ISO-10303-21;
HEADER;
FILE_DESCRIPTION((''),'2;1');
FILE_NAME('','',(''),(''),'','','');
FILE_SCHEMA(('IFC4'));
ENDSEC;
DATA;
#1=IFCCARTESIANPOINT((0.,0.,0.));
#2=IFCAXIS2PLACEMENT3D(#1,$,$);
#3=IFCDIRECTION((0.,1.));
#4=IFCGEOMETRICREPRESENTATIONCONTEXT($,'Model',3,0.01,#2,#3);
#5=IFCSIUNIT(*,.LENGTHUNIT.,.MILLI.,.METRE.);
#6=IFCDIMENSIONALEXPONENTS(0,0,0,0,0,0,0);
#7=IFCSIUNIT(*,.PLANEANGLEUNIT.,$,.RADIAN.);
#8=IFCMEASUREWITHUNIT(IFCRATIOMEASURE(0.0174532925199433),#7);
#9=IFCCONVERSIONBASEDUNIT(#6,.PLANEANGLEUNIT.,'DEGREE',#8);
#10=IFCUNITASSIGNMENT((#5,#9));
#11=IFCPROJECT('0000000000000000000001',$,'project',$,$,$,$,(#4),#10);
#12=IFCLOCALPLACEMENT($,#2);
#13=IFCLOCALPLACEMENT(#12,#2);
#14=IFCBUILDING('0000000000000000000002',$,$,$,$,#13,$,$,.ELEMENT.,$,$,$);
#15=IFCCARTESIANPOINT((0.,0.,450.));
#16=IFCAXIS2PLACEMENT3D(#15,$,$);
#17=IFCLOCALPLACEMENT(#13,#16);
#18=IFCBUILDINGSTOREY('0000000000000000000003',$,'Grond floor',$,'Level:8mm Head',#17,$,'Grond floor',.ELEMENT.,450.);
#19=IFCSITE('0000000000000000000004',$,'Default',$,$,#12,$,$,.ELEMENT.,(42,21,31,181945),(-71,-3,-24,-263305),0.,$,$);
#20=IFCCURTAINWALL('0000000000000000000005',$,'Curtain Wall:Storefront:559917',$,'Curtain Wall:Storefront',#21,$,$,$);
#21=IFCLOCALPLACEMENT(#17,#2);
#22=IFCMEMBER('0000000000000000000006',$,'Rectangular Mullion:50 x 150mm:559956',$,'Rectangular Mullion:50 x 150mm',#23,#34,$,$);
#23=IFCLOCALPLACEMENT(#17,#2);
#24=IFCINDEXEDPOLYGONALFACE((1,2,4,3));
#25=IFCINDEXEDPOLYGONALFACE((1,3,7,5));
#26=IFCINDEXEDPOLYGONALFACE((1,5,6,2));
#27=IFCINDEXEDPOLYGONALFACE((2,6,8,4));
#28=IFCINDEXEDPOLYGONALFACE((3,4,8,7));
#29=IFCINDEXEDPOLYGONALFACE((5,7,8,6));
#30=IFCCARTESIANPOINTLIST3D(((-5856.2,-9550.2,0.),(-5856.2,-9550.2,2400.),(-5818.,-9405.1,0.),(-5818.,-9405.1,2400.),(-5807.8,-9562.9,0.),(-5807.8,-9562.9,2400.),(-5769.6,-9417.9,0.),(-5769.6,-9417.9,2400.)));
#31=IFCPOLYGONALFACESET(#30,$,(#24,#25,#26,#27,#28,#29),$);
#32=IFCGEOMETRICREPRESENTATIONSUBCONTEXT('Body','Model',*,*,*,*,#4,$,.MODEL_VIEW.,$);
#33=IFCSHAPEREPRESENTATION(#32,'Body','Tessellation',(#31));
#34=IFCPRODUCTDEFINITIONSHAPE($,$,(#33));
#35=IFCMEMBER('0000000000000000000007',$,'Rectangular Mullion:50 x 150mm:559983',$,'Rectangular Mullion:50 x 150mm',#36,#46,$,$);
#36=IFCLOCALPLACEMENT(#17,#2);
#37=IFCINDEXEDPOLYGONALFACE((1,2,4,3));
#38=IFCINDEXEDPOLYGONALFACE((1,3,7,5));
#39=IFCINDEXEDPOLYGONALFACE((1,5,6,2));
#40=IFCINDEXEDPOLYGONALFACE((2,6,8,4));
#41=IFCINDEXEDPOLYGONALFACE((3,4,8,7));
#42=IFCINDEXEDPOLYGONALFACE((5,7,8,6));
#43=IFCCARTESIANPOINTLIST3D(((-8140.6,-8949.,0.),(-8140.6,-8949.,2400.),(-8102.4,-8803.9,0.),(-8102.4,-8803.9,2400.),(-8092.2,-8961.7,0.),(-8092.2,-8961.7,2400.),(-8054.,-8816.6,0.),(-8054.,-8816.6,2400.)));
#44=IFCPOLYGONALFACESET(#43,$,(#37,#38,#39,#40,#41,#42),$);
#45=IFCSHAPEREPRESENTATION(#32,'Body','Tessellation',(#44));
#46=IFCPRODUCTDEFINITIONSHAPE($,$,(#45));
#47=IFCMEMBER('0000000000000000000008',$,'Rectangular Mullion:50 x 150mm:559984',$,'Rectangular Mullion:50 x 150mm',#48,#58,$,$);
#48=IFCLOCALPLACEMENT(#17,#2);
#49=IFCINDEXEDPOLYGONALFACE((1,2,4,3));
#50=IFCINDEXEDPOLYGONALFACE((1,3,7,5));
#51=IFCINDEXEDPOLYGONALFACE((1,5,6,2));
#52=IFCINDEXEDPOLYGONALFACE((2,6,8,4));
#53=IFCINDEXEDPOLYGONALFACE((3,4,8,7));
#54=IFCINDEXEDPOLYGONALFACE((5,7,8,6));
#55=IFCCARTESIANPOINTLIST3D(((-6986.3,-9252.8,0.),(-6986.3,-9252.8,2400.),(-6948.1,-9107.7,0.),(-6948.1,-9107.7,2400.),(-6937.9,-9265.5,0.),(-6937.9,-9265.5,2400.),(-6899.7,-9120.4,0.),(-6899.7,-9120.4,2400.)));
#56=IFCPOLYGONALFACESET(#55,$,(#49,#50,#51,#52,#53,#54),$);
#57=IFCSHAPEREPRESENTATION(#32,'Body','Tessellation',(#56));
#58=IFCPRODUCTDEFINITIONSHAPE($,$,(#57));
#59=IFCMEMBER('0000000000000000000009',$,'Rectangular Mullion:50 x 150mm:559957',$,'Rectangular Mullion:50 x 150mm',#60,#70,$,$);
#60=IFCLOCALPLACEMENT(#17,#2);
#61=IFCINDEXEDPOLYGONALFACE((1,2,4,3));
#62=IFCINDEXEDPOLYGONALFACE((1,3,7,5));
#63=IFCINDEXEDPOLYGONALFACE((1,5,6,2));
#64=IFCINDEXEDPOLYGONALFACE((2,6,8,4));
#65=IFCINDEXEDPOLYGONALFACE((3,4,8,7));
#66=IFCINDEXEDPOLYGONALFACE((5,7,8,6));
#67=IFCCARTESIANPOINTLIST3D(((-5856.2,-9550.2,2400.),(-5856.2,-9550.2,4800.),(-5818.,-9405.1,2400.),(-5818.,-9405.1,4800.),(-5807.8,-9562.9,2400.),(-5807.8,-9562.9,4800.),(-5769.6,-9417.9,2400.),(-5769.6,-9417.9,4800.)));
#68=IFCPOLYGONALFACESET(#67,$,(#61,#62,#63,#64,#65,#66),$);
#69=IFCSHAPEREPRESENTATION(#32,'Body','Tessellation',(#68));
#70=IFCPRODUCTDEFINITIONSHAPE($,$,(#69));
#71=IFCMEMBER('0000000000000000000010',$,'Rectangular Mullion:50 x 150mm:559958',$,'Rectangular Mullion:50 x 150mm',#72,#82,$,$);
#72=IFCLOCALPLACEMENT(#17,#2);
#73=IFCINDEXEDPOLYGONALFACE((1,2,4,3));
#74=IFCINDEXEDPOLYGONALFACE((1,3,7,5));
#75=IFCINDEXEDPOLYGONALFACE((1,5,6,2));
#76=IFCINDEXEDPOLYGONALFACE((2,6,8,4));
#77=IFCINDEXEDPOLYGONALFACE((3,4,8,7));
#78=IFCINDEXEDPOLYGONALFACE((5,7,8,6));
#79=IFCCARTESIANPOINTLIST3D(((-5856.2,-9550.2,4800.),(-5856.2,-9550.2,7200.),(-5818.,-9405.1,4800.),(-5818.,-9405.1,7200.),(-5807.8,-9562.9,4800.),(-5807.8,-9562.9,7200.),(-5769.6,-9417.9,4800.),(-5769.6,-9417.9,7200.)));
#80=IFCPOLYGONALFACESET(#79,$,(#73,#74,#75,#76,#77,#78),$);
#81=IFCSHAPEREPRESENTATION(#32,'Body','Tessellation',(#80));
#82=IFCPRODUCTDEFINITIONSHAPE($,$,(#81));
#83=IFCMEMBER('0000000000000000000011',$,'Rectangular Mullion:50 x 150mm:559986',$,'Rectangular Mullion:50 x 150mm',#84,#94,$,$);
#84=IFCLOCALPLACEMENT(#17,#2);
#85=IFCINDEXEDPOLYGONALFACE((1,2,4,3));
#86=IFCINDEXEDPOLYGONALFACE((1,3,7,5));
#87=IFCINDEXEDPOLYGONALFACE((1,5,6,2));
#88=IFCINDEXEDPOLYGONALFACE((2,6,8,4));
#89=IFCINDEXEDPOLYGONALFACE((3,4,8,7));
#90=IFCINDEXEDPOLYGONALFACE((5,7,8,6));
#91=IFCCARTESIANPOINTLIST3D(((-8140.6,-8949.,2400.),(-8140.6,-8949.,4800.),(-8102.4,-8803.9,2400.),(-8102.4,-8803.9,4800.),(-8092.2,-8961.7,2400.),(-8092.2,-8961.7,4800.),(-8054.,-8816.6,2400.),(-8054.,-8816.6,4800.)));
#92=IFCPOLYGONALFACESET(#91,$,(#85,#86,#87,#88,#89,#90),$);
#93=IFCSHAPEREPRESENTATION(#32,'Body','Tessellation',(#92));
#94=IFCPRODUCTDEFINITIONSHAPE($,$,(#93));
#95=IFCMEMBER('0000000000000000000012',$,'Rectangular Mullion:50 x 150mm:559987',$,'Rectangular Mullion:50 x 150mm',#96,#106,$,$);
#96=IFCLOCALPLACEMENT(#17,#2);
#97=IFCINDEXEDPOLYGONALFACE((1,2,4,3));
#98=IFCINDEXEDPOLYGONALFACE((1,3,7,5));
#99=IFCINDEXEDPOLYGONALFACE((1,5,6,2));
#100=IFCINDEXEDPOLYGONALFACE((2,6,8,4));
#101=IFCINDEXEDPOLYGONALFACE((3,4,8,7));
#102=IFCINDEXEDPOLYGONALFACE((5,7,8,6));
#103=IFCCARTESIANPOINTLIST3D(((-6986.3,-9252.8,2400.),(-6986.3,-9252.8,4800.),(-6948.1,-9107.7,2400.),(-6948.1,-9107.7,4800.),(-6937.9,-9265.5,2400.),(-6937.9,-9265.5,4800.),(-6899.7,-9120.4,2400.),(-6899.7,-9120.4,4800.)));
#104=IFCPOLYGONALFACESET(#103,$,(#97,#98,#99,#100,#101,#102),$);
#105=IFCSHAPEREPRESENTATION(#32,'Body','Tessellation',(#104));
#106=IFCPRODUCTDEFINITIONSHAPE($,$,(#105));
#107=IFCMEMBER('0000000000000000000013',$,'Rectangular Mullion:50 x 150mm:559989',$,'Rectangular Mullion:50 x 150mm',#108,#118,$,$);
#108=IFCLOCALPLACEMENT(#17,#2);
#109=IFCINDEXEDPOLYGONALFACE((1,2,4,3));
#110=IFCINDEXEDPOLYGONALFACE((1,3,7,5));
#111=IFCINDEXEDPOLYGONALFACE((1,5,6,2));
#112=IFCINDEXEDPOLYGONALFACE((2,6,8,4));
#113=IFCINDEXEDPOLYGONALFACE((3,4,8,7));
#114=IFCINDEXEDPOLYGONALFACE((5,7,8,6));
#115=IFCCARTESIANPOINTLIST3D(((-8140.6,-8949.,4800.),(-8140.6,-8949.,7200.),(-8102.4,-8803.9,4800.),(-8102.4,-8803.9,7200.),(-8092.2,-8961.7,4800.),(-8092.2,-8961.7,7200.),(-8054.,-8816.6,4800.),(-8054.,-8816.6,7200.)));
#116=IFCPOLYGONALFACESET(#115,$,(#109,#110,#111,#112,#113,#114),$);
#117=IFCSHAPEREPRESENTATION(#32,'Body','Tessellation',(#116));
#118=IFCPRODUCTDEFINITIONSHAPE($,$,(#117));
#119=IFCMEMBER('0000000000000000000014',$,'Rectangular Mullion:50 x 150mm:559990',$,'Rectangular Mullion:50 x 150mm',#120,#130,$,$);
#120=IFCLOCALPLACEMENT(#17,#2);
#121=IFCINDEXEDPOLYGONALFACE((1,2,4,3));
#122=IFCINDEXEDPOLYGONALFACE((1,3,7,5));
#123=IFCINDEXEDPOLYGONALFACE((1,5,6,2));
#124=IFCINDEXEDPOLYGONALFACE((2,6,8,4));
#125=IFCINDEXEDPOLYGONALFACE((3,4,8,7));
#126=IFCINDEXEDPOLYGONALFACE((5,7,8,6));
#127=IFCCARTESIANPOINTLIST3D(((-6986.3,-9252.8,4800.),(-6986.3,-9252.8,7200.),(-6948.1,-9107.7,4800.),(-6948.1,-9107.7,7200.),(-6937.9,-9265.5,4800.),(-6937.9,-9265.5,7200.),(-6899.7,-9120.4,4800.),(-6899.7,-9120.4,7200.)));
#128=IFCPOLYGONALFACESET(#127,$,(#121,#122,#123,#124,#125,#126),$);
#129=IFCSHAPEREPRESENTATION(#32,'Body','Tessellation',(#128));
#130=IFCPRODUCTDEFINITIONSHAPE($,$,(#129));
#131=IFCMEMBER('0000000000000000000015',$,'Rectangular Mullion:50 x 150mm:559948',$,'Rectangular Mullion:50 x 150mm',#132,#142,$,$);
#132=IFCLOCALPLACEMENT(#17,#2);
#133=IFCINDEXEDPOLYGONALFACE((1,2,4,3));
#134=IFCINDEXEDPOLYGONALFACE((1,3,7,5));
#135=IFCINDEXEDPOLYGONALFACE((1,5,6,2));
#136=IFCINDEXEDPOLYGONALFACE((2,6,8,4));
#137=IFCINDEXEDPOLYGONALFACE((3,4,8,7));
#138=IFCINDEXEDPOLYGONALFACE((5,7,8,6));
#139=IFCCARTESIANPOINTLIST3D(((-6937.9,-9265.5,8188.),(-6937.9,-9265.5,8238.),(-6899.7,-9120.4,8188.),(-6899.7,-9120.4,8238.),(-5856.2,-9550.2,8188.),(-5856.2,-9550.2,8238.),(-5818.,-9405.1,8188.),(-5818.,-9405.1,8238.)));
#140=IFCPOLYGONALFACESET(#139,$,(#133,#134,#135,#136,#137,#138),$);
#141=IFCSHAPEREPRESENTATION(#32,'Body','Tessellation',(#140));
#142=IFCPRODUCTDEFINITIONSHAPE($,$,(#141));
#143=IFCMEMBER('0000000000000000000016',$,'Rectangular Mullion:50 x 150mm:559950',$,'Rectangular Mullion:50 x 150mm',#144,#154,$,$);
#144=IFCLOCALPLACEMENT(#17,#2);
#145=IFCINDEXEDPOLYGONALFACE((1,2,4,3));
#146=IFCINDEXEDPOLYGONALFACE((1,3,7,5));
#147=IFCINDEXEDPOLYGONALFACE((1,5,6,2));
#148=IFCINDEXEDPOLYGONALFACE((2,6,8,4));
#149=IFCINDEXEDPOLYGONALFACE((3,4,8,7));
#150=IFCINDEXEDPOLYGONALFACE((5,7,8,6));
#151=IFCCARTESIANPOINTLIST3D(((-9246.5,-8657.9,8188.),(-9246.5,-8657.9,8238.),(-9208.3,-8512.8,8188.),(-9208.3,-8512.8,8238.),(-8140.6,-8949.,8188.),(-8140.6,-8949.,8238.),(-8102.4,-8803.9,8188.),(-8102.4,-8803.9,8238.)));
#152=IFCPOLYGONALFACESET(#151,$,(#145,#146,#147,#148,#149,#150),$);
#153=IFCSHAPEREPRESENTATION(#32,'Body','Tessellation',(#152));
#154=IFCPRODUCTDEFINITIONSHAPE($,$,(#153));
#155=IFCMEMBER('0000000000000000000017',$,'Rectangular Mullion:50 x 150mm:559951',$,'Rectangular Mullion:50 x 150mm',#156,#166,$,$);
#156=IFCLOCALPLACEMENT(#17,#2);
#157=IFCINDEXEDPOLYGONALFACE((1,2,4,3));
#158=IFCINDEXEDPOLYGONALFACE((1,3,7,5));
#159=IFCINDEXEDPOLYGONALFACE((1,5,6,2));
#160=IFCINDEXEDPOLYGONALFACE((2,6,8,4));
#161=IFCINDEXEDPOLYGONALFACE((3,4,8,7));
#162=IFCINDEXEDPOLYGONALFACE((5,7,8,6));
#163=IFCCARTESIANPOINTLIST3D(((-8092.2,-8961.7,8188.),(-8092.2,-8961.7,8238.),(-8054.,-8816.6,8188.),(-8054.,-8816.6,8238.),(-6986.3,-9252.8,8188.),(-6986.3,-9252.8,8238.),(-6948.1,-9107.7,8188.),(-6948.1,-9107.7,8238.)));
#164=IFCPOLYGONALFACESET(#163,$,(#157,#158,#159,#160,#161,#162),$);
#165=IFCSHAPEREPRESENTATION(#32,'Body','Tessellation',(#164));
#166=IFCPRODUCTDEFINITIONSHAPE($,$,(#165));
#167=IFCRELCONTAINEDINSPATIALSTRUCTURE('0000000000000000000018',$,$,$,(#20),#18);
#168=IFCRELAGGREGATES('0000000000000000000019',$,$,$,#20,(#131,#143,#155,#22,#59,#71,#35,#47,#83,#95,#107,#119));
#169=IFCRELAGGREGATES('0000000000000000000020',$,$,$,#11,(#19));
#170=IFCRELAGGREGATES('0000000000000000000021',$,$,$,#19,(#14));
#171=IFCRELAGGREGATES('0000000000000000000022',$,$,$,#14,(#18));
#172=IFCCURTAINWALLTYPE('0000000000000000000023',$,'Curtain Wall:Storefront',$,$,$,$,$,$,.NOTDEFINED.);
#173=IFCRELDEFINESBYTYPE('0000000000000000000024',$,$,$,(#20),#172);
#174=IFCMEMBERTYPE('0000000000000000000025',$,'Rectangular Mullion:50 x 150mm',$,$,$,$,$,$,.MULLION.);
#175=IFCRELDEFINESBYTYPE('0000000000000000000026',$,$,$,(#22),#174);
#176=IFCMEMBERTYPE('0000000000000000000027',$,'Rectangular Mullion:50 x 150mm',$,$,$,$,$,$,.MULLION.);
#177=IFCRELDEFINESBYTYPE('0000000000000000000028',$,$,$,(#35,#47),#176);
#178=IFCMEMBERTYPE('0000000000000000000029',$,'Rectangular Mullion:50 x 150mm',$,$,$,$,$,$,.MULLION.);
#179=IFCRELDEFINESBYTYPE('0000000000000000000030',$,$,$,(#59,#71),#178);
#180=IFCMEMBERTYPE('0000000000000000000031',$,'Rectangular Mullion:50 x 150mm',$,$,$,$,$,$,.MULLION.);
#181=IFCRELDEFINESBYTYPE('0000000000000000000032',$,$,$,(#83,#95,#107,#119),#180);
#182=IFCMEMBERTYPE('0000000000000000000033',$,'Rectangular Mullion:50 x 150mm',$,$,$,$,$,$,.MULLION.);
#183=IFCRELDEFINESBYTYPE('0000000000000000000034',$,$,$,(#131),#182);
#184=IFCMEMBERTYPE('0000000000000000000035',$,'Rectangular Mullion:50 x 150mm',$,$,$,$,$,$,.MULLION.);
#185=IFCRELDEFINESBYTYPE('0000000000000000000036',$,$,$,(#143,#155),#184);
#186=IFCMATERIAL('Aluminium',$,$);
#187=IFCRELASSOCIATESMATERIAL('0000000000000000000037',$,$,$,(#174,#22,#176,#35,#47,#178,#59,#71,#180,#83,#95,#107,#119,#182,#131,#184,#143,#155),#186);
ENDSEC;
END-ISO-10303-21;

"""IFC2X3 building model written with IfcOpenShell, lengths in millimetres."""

from ifc_helpers import new_model, entity, si_unit, converted_unit, direction, frame, frame_2d, origin, origin_2d_with_axis, place, context, subcontext, project, spatial, rectangle, extrude, source, transform, mapped, material, type_object, type_shapes, element, aggregate, save


model = new_model("IFC2X3")

# Units and contexts
model_context = context("Model", 3, precision=0.01, world=origin(), true_north=direction((0.0, 1.0)))
body_context = subcontext(model_context, "Body", "Model", "MODEL_VIEW")
ifc_project = project(units=[si_unit("LENGTHUNIT", "METRE", prefix="MILLI"), converted_unit("PLANEANGLEUNIT", "DEGREE", entity("IfcRatioMeasure", 0.0174532925199433), si_unit("PLANEANGLEUNIT", "RADIAN"), dimensions=[0, 0, 0, 0, 0, 0, 0])], contexts=[model_context])

# Site, building, storey
site_placement = place(None, origin())
site = spatial("IfcSite", under=ifc_project, at=site_placement, Name="Default", CompositionType="ELEMENT", RefLatitude=(42, 21, 31, 181945), RefLongitude=(-71, -3, -24, -263305), RefElevation=0.0)
building_placement = place(site_placement, origin())
building = spatial("IfcBuilding", under=site, at=building_placement, CompositionType="ELEMENT")
storey_placement = place(building_placement, frame((0.0, 0.0, 450.0)))
storey = spatial("IfcBuildingStorey", under=building, at=storey_placement, Name="Grond floor", ObjectType="Level:8mm Head", LongName="Grond floor", CompositionType="ELEMENT", Elevation=450.0)

# Curtain wall, members
curtain_wall_type = type_object("IfcCurtainWallType", Name="Curtain Wall:Storefront", PredefinedType="NOTDEFINED")
curtain_wall_placement = place(storey_placement, frame((0.0, 0.0, -450.0)))
curtain_wall = element("IfcCurtainWall", 1, at=curtain_wall_placement, inside=storey, type_object=curtain_wall_type, Name="Curtain Wall:Storefront:559917", ObjectType="Curtain Wall:Storefront")
ifc_material_1 = material(Name="Aluminium")
member_type_1 = type_object("IfcMemberType", Name="Rectangular Mullion:50 x 150mm", PredefinedType="MULLION", material=ifc_material_1)
shared_shape_1 = source(origin(), body_context, "Body", "SweptSolid", [
    extrude(rectangle(XDim=150.0, YDim=50.0, at=origin_2d_with_axis()), frame((-25.0, 0.0, -2400.0), z_axis=(0.0, 0.0, 1.0), x_axis=(0.0, -1.0, 0.0)), (0.0, 0.0, 1.0), 2400.0),
])
type_shapes(member_type_1, [shared_shape_1])
member_1_placement = place(storey_placement, frame((-5788.7, -9490.4, 0.0), z_axis=(0.0, 0.0, -1.0), x_axis=(0.967067, -0.25452, 0.0)))
member_1 = element("IfcMember", 2, at=member_1_placement, type_object=member_type_1, material=ifc_material_1, Name="Rectangular Mullion:50 x 150mm:559956", ObjectType="Rectangular Mullion:50 x 150mm", context=body_context, shape_type="MappedRepresentation", body=[
    mapped(shared_shape_1, transform((0.0, 0.0, 0.0), scale=1.0)),
])
member_type_2 = type_object("IfcMemberType", Name="Rectangular Mullion:50 x 150mm", PredefinedType="MULLION", material=ifc_material_1)
shared_shape_2 = source(origin(), body_context, "Body", "SweptSolid", [
    extrude(rectangle(XDim=150.0, YDim=50.0, at=origin_2d_with_axis()), frame((0.0, 0.0, -2400.0), z_axis=(0.0, 0.0, 1.0), x_axis=(0.0, -1.0, 0.0)), (0.0, 0.0, 1.0), 2400.0),
])
type_shapes(member_type_2, [shared_shape_2])
member_2_placement = place(storey_placement, frame((-8097.3, -8882.8, 0.0), z_axis=(0.0, 0.0, -1.0), x_axis=(0.967067, -0.25452, 0.0)))
member_2 = element("IfcMember", 3, at=member_2_placement, type_object=member_type_2, material=ifc_material_1, Name="Rectangular Mullion:50 x 150mm:559983", ObjectType="Rectangular Mullion:50 x 150mm", context=body_context, shape_type="MappedRepresentation", body=[
    mapped(shared_shape_2, transform((0.0, 0.0, 0.0), scale=1.0)),
])
member_3_placement = place(storey_placement, frame((-6943.0, -9186.6, 0.0), z_axis=(0.0, 0.0, -1.0), x_axis=(0.967067, -0.25452, 0.0)))
member_3 = element("IfcMember", 4, at=member_3_placement, type_object=member_type_2, material=ifc_material_1, Name="Rectangular Mullion:50 x 150mm:559984", ObjectType="Rectangular Mullion:50 x 150mm", context=body_context, shape_type="MappedRepresentation", body=[
    mapped(shared_shape_2, transform((0.0, 0.0, 0.0), scale=1.0)),
])
member_type_3 = type_object("IfcMemberType", Name="Rectangular Mullion:50 x 150mm", PredefinedType="MULLION", material=ifc_material_1)
shared_shape_3 = source(origin(), body_context, "Body", "SweptSolid", [
    extrude(rectangle(XDim=150.0, YDim=50.0, at=origin_2d_with_axis()), frame((-25.0, 0.0, -2400.0), z_axis=(0.0, 0.0, 1.0), x_axis=(0.0, -1.0, 0.0)), (0.0, 0.0, 1.0), 2400.0),
])
type_shapes(member_type_3, [shared_shape_3])
member_4_placement = place(storey_placement, frame((-5788.7, -9490.4, 2400.0), z_axis=(0.0, 0.0, -1.0), x_axis=(0.967067, -0.25452, 0.0)))
member_4 = element("IfcMember", 5, at=member_4_placement, type_object=member_type_3, material=ifc_material_1, Name="Rectangular Mullion:50 x 150mm:559957", ObjectType="Rectangular Mullion:50 x 150mm", context=body_context, shape_type="MappedRepresentation", body=[
    mapped(shared_shape_3, transform((0.0, 0.0, 0.0), scale=1.0)),
])
member_5_placement = place(storey_placement, frame((-5788.7, -9490.4, 4800.0), z_axis=(0.0, 0.0, -1.0), x_axis=(0.967067, -0.25452, 0.0)))
member_5 = element("IfcMember", 6, at=member_5_placement, type_object=member_type_3, material=ifc_material_1, Name="Rectangular Mullion:50 x 150mm:559958", ObjectType="Rectangular Mullion:50 x 150mm", context=body_context, shape_type="MappedRepresentation", body=[
    mapped(shared_shape_3, transform((0.0, 0.0, 0.0), scale=1.0)),
])
member_type_4 = type_object("IfcMemberType", Name="Rectangular Mullion:50 x 150mm", PredefinedType="MULLION", material=ifc_material_1)
shared_shape_4 = source(origin(), body_context, "Body", "SweptSolid", [
    extrude(rectangle(XDim=150.0, YDim=50.0, at=origin_2d_with_axis()), frame((0.0, 0.0, -2400.0), z_axis=(0.0, 0.0, 1.0), x_axis=(0.0, -1.0, 0.0)), (0.0, 0.0, 1.0), 2400.0),
])
type_shapes(member_type_4, [shared_shape_4])
member_6_placement = place(storey_placement, frame((-8097.3, -8882.8, 2400.0), z_axis=(0.0, 0.0, -1.0), x_axis=(0.967067, -0.25452, 0.0)))
member_6 = element("IfcMember", 7, at=member_6_placement, type_object=member_type_4, material=ifc_material_1, Name="Rectangular Mullion:50 x 150mm:559986", ObjectType="Rectangular Mullion:50 x 150mm", context=body_context, shape_type="MappedRepresentation", body=[
    mapped(shared_shape_4, transform((0.0, 0.0, 0.0), scale=1.0)),
])
member_7_placement = place(storey_placement, frame((-6943.0, -9186.6, 2400.0), z_axis=(0.0, 0.0, -1.0), x_axis=(0.967067, -0.25452, 0.0)))
member_7 = element("IfcMember", 8, at=member_7_placement, type_object=member_type_4, material=ifc_material_1, Name="Rectangular Mullion:50 x 150mm:559987", ObjectType="Rectangular Mullion:50 x 150mm", context=body_context, shape_type="MappedRepresentation", body=[
    mapped(shared_shape_4, transform((0.0, 0.0, 0.0), scale=1.0)),
])
member_8_placement = place(storey_placement, frame((-8097.3, -8882.8, 4800.0), z_axis=(0.0, 0.0, -1.0), x_axis=(0.967067, -0.25452, 0.0)))
member_8 = element("IfcMember", 9, at=member_8_placement, type_object=member_type_4, material=ifc_material_1, Name="Rectangular Mullion:50 x 150mm:559989", ObjectType="Rectangular Mullion:50 x 150mm", context=body_context, shape_type="MappedRepresentation", body=[
    mapped(shared_shape_4, transform((0.0, 0.0, 0.0), scale=1.0)),
])
member_9_placement = place(storey_placement, frame((-6943.0, -9186.6, 4800.0), z_axis=(0.0, 0.0, -1.0), x_axis=(0.967067, -0.25452, 0.0)))
member_9 = element("IfcMember", 10, at=member_9_placement, type_object=member_type_4, material=ifc_material_1, Name="Rectangular Mullion:50 x 150mm:559990", ObjectType="Rectangular Mullion:50 x 150mm", context=body_context, shape_type="MappedRepresentation", body=[
    mapped(shared_shape_4, transform((0.0, 0.0, 0.0), scale=1.0)),
])
member_type_5 = type_object("IfcMemberType", Name="Rectangular Mullion:50 x 150mm", PredefinedType="MULLION", material=ifc_material_1)
shared_shape_5 = source(origin(), body_context, "Body", "SweptSolid", [
    extrude(rectangle(XDim=150.0, YDim=50.0, at=origin_2d_with_axis()), frame((-25.0, 0.0, -1118.6), z_axis=(0.0, 0.0, 1.0), x_axis=(0.0, -1.0, 0.0)), (0.0, 0.0, 1.0), 1118.6),
])
type_shapes(member_type_5, [shared_shape_5])
member_10_placement = place(storey_placement, frame((-5837.1, -9477.7, 8238.0), z_axis=(0.967067, -0.25452, 0.0), x_axis=(0.0, 0.0, 1.0)))
member_10 = element("IfcMember", 11, at=member_10_placement, type_object=member_type_5, material=ifc_material_1, Name="Rectangular Mullion:50 x 150mm:559948", ObjectType="Rectangular Mullion:50 x 150mm", context=body_context, shape_type="MappedRepresentation", body=[
    mapped(shared_shape_5, transform((0.0, 0.0, 0.0), scale=1.0)),
])
member_type_6 = type_object("IfcMemberType", Name="Rectangular Mullion:50 x 150mm", PredefinedType="MULLION", material=ifc_material_1)
shared_shape_6 = source(origin(), body_context, "Body", "SweptSolid", [
    extrude(rectangle(XDim=150.0, YDim=50.0, at=frame_2d((0.0, 0.0), x_axis=(1.0, 0.0))), frame((-25.0, 0.0, -1143.6), z_axis=(0.0, 0.0, 1.0), x_axis=(0.0, -1.0, 0.0)), (0.0, 0.0, 1.0), 1143.6),
])
type_shapes(member_type_6, [shared_shape_6])
member_11_placement = place(storey_placement, frame((-8121.5, -8876.4, 8238.0), z_axis=(0.967067, -0.25452, 0.0), x_axis=(0.0, 0.0, 1.0)))
member_11 = element("IfcMember", 12, at=member_11_placement, type_object=member_type_6, material=ifc_material_1, Name="Rectangular Mullion:50 x 150mm:559950", ObjectType="Rectangular Mullion:50 x 150mm", context=body_context, shape_type="MappedRepresentation", body=[
    mapped(shared_shape_6, transform((0.0, 0.0, 0.0), scale=1.0)),
])
member_12_placement = place(storey_placement, frame((-6967.2, -9180.2, 8238.0), z_axis=(0.967067, -0.25452, 0.0), x_axis=(0.0, 0.0, 1.0)))
member_12 = element("IfcMember", 13, at=member_12_placement, type_object=member_type_6, material=ifc_material_1, Name="Rectangular Mullion:50 x 150mm:559951", ObjectType="Rectangular Mullion:50 x 150mm", context=body_context, shape_type="MappedRepresentation", body=[
    mapped(shared_shape_6, transform((0.0, 0.0, 0.0), scale=1.0)),
])

aggregate(curtain_wall, [member_10, member_11, member_12, member_1, member_4, member_5, member_2, member_3, member_6, member_7, member_8, member_9])

save(model, "model.ifc")
